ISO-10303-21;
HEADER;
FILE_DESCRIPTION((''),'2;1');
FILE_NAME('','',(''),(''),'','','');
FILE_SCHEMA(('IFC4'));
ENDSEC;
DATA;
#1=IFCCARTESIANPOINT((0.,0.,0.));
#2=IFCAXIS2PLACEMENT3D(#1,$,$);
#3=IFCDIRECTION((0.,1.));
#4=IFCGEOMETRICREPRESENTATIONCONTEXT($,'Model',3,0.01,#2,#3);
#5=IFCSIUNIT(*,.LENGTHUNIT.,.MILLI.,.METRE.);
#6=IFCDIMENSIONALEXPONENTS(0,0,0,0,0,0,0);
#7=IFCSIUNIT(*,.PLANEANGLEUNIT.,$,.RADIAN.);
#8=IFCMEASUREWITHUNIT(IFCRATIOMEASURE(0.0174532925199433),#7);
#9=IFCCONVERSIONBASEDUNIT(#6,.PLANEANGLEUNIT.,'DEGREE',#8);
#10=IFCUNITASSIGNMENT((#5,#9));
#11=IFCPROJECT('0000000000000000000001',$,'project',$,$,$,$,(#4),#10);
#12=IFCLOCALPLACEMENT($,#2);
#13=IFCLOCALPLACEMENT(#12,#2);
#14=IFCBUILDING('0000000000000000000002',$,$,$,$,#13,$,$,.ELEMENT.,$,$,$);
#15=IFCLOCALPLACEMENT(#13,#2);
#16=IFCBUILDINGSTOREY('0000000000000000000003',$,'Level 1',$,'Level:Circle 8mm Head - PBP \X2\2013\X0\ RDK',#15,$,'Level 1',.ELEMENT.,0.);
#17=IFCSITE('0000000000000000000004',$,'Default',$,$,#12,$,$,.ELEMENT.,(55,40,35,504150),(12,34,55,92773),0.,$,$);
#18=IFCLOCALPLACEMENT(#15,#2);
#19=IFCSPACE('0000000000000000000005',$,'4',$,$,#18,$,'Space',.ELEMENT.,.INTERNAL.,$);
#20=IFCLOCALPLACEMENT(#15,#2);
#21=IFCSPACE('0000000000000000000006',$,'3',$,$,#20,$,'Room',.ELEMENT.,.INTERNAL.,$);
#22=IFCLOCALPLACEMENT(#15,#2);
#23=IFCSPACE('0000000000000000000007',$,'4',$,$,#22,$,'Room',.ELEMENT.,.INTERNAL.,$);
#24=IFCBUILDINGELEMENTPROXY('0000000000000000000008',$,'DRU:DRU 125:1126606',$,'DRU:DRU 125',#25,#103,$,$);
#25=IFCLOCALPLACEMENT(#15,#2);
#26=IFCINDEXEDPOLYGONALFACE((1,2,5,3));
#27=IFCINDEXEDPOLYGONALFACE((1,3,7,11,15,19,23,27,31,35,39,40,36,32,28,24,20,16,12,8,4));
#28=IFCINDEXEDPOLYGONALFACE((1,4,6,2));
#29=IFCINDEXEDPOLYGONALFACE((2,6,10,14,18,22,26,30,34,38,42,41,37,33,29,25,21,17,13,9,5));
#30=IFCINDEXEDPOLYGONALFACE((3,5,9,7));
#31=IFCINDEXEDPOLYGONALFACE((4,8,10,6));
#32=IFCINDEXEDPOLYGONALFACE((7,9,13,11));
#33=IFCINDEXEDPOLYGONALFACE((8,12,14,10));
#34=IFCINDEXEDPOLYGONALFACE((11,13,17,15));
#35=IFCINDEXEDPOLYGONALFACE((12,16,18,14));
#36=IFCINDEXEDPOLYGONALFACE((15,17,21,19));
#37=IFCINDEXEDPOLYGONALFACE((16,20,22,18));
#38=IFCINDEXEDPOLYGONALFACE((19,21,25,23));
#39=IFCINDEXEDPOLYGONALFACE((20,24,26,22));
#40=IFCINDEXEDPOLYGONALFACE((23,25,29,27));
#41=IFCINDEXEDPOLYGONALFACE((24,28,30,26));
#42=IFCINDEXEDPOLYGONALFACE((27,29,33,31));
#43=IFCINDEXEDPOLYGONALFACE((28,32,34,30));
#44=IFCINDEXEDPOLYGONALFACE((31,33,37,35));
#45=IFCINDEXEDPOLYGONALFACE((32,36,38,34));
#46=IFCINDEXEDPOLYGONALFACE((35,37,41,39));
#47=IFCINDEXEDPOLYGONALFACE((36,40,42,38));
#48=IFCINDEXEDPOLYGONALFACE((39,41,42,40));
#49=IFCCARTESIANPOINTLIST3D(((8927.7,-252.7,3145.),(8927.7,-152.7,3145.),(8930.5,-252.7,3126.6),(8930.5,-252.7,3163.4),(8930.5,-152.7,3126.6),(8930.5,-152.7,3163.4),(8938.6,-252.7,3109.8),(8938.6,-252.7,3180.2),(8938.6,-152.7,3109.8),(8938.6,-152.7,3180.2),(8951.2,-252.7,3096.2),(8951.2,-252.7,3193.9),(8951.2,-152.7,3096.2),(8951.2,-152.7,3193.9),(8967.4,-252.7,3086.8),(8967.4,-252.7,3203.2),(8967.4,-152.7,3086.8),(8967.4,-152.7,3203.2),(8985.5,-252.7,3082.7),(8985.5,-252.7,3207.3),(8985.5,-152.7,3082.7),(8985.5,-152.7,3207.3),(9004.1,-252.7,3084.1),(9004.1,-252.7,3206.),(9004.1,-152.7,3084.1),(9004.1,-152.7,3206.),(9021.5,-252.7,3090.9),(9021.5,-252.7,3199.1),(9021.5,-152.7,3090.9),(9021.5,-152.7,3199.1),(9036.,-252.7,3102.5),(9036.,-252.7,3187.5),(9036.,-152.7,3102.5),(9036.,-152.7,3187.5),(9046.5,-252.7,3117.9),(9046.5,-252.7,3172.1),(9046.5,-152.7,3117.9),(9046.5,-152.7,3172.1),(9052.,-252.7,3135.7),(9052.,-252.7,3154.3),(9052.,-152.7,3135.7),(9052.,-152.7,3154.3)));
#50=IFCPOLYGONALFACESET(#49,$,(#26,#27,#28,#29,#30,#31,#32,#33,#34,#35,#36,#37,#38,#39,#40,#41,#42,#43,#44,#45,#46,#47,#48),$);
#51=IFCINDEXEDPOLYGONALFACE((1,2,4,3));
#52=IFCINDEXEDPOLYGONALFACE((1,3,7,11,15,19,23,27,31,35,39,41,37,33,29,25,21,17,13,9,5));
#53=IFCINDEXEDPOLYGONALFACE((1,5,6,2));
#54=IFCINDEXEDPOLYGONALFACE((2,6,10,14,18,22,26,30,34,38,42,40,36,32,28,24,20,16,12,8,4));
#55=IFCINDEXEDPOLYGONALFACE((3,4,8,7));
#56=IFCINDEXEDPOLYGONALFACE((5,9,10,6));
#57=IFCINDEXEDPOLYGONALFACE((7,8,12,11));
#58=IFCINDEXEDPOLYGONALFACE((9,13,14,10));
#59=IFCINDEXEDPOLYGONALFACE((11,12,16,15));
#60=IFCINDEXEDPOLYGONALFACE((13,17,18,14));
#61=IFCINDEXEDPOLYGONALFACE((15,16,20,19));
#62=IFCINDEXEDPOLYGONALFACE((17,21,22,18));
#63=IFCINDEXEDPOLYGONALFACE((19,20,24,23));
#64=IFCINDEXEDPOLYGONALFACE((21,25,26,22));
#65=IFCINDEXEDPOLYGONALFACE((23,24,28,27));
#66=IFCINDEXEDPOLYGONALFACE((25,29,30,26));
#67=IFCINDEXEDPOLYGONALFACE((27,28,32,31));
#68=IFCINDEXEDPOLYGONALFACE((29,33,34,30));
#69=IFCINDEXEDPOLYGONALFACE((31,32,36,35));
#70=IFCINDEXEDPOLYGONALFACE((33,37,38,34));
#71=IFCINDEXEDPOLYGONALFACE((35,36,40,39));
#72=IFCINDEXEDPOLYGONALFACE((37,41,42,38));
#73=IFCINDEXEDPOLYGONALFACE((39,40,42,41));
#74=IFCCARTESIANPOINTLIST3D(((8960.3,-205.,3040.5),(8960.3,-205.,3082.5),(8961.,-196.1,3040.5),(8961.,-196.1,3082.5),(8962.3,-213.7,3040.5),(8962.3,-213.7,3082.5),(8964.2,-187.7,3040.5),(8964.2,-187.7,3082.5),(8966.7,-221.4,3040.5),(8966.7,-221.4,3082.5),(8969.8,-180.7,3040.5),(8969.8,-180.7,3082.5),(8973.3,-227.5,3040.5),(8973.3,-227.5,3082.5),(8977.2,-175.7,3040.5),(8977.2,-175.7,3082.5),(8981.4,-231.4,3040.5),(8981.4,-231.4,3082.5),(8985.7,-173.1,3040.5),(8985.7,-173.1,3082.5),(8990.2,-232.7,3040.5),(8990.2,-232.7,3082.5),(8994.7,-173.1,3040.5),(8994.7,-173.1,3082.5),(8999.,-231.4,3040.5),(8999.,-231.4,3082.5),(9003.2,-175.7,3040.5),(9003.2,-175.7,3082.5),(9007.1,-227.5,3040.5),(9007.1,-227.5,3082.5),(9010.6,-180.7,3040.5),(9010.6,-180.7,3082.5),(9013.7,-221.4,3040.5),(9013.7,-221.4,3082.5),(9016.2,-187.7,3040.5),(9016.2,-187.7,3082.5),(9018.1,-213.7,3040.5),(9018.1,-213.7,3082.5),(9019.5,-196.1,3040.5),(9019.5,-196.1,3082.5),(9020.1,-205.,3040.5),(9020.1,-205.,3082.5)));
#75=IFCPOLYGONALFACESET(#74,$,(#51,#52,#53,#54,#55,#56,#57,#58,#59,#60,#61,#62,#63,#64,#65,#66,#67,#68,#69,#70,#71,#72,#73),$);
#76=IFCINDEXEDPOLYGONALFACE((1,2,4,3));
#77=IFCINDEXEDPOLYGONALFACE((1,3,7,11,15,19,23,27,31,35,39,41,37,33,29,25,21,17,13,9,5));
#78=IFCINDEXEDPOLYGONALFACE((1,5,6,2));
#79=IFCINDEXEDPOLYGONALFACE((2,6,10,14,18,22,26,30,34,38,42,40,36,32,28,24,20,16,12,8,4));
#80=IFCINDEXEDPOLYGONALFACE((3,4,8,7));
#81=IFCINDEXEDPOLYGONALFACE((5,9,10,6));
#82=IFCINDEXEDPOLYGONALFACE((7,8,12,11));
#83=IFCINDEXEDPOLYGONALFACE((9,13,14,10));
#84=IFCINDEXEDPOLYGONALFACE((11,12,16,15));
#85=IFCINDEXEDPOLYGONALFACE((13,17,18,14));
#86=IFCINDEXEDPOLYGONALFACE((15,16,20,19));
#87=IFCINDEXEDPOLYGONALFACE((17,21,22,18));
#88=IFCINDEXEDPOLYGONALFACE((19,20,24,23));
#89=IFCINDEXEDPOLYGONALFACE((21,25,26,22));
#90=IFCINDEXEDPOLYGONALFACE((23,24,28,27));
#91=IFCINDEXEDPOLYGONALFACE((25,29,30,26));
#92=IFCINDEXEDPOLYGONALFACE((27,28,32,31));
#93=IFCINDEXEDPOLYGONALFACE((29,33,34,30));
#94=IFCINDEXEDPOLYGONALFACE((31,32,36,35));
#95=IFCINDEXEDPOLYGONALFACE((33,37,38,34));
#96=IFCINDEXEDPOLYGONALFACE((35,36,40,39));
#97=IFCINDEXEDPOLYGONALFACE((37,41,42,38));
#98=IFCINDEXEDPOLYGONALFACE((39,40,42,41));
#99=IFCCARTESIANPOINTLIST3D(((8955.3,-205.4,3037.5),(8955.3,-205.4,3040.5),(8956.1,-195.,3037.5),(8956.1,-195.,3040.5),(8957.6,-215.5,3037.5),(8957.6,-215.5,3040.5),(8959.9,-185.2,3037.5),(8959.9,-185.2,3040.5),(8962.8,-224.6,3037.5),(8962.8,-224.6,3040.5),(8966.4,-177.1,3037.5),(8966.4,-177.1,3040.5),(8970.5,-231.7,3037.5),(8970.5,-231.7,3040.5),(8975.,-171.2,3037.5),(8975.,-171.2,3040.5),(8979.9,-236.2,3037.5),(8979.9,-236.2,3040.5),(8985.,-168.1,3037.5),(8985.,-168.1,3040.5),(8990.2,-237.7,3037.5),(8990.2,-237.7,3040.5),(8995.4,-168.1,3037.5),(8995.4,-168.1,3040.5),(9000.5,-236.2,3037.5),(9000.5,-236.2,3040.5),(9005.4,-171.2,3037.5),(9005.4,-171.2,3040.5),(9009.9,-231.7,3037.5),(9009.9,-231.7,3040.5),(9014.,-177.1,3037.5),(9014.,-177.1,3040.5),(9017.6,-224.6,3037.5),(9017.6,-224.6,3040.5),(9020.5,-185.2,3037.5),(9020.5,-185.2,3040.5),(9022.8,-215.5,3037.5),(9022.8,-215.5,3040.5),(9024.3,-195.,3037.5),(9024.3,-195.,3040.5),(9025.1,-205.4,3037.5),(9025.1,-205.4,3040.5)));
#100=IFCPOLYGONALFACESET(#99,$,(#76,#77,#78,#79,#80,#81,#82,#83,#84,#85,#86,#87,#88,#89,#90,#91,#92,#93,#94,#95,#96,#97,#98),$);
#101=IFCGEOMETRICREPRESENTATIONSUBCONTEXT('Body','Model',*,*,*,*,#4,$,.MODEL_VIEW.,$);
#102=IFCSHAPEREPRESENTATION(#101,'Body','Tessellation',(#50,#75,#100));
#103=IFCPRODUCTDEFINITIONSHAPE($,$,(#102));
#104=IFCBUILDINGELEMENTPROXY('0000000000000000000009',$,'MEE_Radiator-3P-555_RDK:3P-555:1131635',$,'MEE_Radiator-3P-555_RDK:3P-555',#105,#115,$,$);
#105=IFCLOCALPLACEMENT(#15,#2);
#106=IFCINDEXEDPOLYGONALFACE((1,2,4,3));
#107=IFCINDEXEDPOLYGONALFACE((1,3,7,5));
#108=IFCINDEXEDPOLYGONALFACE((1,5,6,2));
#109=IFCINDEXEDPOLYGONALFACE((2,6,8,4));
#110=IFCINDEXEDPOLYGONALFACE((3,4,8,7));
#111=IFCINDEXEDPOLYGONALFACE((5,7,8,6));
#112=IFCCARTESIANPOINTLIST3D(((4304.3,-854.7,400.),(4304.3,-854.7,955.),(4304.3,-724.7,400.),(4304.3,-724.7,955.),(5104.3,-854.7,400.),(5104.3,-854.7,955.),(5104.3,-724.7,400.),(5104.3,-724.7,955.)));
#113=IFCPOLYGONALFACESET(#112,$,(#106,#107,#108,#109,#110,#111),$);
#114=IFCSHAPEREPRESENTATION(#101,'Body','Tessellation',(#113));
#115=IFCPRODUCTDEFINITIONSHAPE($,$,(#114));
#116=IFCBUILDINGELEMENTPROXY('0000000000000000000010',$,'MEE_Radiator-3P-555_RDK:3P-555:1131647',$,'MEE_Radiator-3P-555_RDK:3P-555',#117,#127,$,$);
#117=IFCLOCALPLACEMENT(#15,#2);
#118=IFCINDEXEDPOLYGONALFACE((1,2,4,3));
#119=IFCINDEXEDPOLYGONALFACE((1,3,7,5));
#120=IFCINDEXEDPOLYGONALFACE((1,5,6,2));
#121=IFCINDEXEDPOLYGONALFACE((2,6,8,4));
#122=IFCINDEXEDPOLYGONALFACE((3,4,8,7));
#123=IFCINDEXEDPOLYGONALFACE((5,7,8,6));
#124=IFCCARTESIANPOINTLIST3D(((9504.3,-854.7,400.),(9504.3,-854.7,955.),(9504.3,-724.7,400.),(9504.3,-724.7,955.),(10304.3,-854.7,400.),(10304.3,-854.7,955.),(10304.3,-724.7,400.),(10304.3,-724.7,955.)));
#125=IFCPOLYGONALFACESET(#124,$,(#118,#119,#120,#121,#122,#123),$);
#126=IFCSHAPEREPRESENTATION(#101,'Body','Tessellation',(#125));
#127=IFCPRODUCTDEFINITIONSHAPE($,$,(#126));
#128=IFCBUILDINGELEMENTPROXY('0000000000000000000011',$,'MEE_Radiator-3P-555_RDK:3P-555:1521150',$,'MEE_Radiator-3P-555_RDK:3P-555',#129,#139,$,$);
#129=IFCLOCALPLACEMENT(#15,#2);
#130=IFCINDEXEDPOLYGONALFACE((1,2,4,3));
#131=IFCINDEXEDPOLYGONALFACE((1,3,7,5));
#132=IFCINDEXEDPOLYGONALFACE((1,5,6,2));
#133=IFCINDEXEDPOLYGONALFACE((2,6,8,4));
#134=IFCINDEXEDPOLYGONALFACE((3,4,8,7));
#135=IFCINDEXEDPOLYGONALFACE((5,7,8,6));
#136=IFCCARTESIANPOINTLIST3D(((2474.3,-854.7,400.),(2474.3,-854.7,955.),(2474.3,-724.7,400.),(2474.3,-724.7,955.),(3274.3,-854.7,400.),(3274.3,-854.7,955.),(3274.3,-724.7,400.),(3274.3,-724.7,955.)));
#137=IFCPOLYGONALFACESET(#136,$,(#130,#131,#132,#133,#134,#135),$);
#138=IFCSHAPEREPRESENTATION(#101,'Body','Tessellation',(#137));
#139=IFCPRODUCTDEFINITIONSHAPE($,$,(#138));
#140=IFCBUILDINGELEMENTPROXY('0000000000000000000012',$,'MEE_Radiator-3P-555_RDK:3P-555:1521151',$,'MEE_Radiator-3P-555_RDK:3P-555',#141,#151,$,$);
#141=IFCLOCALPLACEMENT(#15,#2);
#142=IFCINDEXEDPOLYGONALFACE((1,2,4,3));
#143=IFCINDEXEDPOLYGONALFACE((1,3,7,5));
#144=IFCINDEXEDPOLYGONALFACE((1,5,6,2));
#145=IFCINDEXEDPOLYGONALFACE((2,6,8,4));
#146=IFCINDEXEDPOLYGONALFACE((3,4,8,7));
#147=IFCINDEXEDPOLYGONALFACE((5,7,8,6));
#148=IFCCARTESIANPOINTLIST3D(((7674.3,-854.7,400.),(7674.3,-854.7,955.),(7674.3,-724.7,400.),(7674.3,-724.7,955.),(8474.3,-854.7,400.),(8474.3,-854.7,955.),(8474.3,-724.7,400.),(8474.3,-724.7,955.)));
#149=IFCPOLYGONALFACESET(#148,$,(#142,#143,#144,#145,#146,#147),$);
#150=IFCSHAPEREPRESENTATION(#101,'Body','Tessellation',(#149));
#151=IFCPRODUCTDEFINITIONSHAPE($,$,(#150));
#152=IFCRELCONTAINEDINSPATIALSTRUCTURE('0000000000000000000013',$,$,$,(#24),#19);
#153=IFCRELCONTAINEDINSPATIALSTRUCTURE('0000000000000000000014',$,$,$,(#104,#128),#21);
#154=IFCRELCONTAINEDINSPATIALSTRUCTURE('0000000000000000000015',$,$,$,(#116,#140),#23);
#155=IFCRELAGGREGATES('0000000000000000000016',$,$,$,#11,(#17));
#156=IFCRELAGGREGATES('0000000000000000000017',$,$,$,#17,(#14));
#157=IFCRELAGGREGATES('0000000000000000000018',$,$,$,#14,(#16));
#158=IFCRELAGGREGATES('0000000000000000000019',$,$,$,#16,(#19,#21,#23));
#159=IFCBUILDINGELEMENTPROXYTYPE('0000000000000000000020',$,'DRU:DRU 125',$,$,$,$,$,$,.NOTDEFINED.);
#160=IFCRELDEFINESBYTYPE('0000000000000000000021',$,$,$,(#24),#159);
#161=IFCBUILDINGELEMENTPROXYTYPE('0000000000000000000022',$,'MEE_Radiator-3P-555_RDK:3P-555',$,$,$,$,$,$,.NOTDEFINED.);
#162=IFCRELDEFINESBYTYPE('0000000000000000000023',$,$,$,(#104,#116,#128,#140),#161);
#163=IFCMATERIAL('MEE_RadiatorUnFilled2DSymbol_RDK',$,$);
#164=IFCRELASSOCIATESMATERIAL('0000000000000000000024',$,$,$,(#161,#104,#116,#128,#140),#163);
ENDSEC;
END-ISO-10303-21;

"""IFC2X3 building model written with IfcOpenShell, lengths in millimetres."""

from ifc_helpers import new_model, entity, si_unit, converted_unit, direction, frame, frame_2d, origin, origin_2d_with_axis, place, context, subcontext, project, spatial, rectangle, circle, extrude, source, transform, mapped, material, type_object, type_shapes, element, save


model = new_model("IFC2X3")

# Units and contexts
model_context = context("Model", 3, precision=0.01, world=origin(), true_north=direction((0.0, 1.0)))
body_context = subcontext(model_context, "Body", "Model", "MODEL_VIEW")
ifc_project = project(units=[si_unit("LENGTHUNIT", "METRE", prefix="MILLI"), converted_unit("PLANEANGLEUNIT", "DEGREE", entity("IfcRatioMeasure", 0.0174532925199433), si_unit("PLANEANGLEUNIT", "RADIAN"), dimensions=[0, 0, 0, 0, 0, 0, 0])], contexts=[model_context])

# Site, building, storey
site_placement = place(None, origin())
site = spatial("IfcSite", under=ifc_project, at=site_placement, Name="Default", CompositionType="ELEMENT", RefLatitude=(55, 40, 35, 504150), RefLongitude=(12, 34, 55, 92773), RefElevation=0.0)
building_placement = place(site_placement, origin())
building = spatial("IfcBuilding", under=site, at=building_placement, CompositionType="ELEMENT")
storey_placement = place(building_placement, origin())
storey = spatial("IfcBuildingStorey", under=building, at=storey_placement, Name="Level 1", ObjectType="Level:Circle 8mm Head - PBP – RDK", LongName="Level 1", CompositionType="ELEMENT", Elevation=0.0)

# Shared definitions
space_1_placement = place(storey_placement, origin())
space_1 = spatial("IfcSpace", under=storey, at=space_1_placement, Name="4", LongName="Space", CompositionType="ELEMENT", InteriorOrExteriorSpace="INTERNAL")

# Building element proxy
building_element_proxy_type_1 = type_object("IfcBuildingElementProxyType", Name="DRU:DRU 125", PredefinedType="NOTDEFINED")
shared_shape_1 = source(origin(), body_context, "Body", "SweptSolid", [
    extrude(circle(Radius=62.5, at=frame_2d((0.0, 0.0), x_axis=(1.0, 0.0))), frame((-50.0, 0.0, 0.0), z_axis=(1.0, 0.0, 0.0), x_axis=(0.0, 1.0, 0.0)), (0.0, 0.0, 1.0), 100.0),
    extrude(circle(Radius=30.0, at=frame_2d((0.0, 0.0), x_axis=(1.0, 0.0))), frame((0.0, 0.0, 62.5)), (0.0, 0.0, 1.0), 42.0),
    extrude(circle(Radius=35.0, at=frame_2d((0.0, 0.0), x_axis=(1.0, 0.0))), frame((0.0, 0.0, 104.5)), (0.0, 0.0, 1.0), 3.0),
])
type_shapes(building_element_proxy_type_1, [shared_shape_1])
proxy_1_placement = place(space_1_placement, frame((8990.2, -202.7, 3145.0), z_axis=(0.0, 0.0, -1.0), x_axis=(0.0, -1.0, 0.0)))
element("IfcBuildingElementProxy", 1, at=proxy_1_placement, inside=space_1, type_object=building_element_proxy_type_1, Name="DRU:DRU 125:1126606", ObjectType="DRU:DRU 125", context=body_context, shape_type="MappedRepresentation", body=[
    mapped(shared_shape_1, transform((0.0, 0.0, 0.0), scale=1.0)),
])

# Shared definitions
space_2_placement = place(storey_placement, origin())
space_2 = spatial("IfcSpace", under=storey, at=space_2_placement, Name="3", LongName="Room", CompositionType="ELEMENT", InteriorOrExteriorSpace="INTERNAL")

# Building element proxy
ifc_material_1 = material(Name="MEE_RadiatorUnFilled2DSymbol_RDK")
building_element_proxy_type_2 = type_object("IfcBuildingElementProxyType", Name="MEE_Radiator-3P-555_RDK:3P-555", PredefinedType="NOTDEFINED", material=ifc_material_1)
shared_shape_2 = source(origin(), body_context, "Body", "SweptSolid", [
    extrude(rectangle(XDim=800.0, YDim=130.0, at=origin_2d_with_axis()), frame((0.0, -65.0, 0.0), z_axis=(0.0, 0.0, 1.0), x_axis=(-1.0, 0.0, 0.0)), (0.0, 0.0, 1.0), 555.0),
])
type_shapes(building_element_proxy_type_2, [shared_shape_2])
proxy_2_placement = place(space_2_placement, frame((4704.3, -854.7, 400.0), z_axis=(0.0, 0.0, 1.0), x_axis=(-1.0, 0.0, 0.0)))
element("IfcBuildingElementProxy", 2, at=proxy_2_placement, inside=space_2, type_object=building_element_proxy_type_2, material=ifc_material_1, Name="MEE_Radiator-3P-555_RDK:3P-555:1131635", ObjectType="MEE_Radiator-3P-555_RDK:3P-555", context=body_context, shape_type="MappedRepresentation", body=[
    mapped(shared_shape_2, transform((0.0, 0.0, 0.0), scale=1.0)),
])

# Shared definitions
space_3_placement = place(storey_placement, origin())
space_3 = spatial("IfcSpace", under=storey, at=space_3_placement, Name="4", LongName="Room", CompositionType="ELEMENT", InteriorOrExteriorSpace="INTERNAL")

# Building element proxies
proxy_3_placement = place(space_3_placement, frame((9904.3, -854.7, 400.0), z_axis=(0.0, 0.0, 1.0), x_axis=(-1.0, 0.0, 0.0)))
element("IfcBuildingElementProxy", 3, at=proxy_3_placement, inside=space_3, type_object=building_element_proxy_type_2, material=ifc_material_1, Name="MEE_Radiator-3P-555_RDK:3P-555:1131647", ObjectType="MEE_Radiator-3P-555_RDK:3P-555", context=body_context, shape_type="MappedRepresentation", body=[
    mapped(shared_shape_2, transform((0.0, 0.0, 0.0), scale=1.0)),
])
proxy_4_placement = place(space_2_placement, frame((2874.3, -854.7, 400.0), z_axis=(0.0, 0.0, 1.0), x_axis=(-1.0, 0.0, 0.0)))
element("IfcBuildingElementProxy", 4, at=proxy_4_placement, inside=space_2, type_object=building_element_proxy_type_2, material=ifc_material_1, Name="MEE_Radiator-3P-555_RDK:3P-555:1521150", ObjectType="MEE_Radiator-3P-555_RDK:3P-555", context=body_context, shape_type="MappedRepresentation", body=[
    mapped(shared_shape_2, transform((0.0, 0.0, 0.0), scale=1.0)),
])
proxy_5_placement = place(space_3_placement, frame((8074.3, -854.7, 400.0), z_axis=(0.0, 0.0, 1.0), x_axis=(-1.0, 0.0, 0.0)))
element("IfcBuildingElementProxy", 5, at=proxy_5_placement, inside=space_3, type_object=building_element_proxy_type_2, material=ifc_material_1, Name="MEE_Radiator-3P-555_RDK:3P-555:1521151", ObjectType="MEE_Radiator-3P-555_RDK:3P-555", context=body_context, shape_type="MappedRepresentation", body=[
    mapped(shared_shape_2, transform((0.0, 0.0, 0.0), scale=1.0)),
])

save(model, "model.ifc")
